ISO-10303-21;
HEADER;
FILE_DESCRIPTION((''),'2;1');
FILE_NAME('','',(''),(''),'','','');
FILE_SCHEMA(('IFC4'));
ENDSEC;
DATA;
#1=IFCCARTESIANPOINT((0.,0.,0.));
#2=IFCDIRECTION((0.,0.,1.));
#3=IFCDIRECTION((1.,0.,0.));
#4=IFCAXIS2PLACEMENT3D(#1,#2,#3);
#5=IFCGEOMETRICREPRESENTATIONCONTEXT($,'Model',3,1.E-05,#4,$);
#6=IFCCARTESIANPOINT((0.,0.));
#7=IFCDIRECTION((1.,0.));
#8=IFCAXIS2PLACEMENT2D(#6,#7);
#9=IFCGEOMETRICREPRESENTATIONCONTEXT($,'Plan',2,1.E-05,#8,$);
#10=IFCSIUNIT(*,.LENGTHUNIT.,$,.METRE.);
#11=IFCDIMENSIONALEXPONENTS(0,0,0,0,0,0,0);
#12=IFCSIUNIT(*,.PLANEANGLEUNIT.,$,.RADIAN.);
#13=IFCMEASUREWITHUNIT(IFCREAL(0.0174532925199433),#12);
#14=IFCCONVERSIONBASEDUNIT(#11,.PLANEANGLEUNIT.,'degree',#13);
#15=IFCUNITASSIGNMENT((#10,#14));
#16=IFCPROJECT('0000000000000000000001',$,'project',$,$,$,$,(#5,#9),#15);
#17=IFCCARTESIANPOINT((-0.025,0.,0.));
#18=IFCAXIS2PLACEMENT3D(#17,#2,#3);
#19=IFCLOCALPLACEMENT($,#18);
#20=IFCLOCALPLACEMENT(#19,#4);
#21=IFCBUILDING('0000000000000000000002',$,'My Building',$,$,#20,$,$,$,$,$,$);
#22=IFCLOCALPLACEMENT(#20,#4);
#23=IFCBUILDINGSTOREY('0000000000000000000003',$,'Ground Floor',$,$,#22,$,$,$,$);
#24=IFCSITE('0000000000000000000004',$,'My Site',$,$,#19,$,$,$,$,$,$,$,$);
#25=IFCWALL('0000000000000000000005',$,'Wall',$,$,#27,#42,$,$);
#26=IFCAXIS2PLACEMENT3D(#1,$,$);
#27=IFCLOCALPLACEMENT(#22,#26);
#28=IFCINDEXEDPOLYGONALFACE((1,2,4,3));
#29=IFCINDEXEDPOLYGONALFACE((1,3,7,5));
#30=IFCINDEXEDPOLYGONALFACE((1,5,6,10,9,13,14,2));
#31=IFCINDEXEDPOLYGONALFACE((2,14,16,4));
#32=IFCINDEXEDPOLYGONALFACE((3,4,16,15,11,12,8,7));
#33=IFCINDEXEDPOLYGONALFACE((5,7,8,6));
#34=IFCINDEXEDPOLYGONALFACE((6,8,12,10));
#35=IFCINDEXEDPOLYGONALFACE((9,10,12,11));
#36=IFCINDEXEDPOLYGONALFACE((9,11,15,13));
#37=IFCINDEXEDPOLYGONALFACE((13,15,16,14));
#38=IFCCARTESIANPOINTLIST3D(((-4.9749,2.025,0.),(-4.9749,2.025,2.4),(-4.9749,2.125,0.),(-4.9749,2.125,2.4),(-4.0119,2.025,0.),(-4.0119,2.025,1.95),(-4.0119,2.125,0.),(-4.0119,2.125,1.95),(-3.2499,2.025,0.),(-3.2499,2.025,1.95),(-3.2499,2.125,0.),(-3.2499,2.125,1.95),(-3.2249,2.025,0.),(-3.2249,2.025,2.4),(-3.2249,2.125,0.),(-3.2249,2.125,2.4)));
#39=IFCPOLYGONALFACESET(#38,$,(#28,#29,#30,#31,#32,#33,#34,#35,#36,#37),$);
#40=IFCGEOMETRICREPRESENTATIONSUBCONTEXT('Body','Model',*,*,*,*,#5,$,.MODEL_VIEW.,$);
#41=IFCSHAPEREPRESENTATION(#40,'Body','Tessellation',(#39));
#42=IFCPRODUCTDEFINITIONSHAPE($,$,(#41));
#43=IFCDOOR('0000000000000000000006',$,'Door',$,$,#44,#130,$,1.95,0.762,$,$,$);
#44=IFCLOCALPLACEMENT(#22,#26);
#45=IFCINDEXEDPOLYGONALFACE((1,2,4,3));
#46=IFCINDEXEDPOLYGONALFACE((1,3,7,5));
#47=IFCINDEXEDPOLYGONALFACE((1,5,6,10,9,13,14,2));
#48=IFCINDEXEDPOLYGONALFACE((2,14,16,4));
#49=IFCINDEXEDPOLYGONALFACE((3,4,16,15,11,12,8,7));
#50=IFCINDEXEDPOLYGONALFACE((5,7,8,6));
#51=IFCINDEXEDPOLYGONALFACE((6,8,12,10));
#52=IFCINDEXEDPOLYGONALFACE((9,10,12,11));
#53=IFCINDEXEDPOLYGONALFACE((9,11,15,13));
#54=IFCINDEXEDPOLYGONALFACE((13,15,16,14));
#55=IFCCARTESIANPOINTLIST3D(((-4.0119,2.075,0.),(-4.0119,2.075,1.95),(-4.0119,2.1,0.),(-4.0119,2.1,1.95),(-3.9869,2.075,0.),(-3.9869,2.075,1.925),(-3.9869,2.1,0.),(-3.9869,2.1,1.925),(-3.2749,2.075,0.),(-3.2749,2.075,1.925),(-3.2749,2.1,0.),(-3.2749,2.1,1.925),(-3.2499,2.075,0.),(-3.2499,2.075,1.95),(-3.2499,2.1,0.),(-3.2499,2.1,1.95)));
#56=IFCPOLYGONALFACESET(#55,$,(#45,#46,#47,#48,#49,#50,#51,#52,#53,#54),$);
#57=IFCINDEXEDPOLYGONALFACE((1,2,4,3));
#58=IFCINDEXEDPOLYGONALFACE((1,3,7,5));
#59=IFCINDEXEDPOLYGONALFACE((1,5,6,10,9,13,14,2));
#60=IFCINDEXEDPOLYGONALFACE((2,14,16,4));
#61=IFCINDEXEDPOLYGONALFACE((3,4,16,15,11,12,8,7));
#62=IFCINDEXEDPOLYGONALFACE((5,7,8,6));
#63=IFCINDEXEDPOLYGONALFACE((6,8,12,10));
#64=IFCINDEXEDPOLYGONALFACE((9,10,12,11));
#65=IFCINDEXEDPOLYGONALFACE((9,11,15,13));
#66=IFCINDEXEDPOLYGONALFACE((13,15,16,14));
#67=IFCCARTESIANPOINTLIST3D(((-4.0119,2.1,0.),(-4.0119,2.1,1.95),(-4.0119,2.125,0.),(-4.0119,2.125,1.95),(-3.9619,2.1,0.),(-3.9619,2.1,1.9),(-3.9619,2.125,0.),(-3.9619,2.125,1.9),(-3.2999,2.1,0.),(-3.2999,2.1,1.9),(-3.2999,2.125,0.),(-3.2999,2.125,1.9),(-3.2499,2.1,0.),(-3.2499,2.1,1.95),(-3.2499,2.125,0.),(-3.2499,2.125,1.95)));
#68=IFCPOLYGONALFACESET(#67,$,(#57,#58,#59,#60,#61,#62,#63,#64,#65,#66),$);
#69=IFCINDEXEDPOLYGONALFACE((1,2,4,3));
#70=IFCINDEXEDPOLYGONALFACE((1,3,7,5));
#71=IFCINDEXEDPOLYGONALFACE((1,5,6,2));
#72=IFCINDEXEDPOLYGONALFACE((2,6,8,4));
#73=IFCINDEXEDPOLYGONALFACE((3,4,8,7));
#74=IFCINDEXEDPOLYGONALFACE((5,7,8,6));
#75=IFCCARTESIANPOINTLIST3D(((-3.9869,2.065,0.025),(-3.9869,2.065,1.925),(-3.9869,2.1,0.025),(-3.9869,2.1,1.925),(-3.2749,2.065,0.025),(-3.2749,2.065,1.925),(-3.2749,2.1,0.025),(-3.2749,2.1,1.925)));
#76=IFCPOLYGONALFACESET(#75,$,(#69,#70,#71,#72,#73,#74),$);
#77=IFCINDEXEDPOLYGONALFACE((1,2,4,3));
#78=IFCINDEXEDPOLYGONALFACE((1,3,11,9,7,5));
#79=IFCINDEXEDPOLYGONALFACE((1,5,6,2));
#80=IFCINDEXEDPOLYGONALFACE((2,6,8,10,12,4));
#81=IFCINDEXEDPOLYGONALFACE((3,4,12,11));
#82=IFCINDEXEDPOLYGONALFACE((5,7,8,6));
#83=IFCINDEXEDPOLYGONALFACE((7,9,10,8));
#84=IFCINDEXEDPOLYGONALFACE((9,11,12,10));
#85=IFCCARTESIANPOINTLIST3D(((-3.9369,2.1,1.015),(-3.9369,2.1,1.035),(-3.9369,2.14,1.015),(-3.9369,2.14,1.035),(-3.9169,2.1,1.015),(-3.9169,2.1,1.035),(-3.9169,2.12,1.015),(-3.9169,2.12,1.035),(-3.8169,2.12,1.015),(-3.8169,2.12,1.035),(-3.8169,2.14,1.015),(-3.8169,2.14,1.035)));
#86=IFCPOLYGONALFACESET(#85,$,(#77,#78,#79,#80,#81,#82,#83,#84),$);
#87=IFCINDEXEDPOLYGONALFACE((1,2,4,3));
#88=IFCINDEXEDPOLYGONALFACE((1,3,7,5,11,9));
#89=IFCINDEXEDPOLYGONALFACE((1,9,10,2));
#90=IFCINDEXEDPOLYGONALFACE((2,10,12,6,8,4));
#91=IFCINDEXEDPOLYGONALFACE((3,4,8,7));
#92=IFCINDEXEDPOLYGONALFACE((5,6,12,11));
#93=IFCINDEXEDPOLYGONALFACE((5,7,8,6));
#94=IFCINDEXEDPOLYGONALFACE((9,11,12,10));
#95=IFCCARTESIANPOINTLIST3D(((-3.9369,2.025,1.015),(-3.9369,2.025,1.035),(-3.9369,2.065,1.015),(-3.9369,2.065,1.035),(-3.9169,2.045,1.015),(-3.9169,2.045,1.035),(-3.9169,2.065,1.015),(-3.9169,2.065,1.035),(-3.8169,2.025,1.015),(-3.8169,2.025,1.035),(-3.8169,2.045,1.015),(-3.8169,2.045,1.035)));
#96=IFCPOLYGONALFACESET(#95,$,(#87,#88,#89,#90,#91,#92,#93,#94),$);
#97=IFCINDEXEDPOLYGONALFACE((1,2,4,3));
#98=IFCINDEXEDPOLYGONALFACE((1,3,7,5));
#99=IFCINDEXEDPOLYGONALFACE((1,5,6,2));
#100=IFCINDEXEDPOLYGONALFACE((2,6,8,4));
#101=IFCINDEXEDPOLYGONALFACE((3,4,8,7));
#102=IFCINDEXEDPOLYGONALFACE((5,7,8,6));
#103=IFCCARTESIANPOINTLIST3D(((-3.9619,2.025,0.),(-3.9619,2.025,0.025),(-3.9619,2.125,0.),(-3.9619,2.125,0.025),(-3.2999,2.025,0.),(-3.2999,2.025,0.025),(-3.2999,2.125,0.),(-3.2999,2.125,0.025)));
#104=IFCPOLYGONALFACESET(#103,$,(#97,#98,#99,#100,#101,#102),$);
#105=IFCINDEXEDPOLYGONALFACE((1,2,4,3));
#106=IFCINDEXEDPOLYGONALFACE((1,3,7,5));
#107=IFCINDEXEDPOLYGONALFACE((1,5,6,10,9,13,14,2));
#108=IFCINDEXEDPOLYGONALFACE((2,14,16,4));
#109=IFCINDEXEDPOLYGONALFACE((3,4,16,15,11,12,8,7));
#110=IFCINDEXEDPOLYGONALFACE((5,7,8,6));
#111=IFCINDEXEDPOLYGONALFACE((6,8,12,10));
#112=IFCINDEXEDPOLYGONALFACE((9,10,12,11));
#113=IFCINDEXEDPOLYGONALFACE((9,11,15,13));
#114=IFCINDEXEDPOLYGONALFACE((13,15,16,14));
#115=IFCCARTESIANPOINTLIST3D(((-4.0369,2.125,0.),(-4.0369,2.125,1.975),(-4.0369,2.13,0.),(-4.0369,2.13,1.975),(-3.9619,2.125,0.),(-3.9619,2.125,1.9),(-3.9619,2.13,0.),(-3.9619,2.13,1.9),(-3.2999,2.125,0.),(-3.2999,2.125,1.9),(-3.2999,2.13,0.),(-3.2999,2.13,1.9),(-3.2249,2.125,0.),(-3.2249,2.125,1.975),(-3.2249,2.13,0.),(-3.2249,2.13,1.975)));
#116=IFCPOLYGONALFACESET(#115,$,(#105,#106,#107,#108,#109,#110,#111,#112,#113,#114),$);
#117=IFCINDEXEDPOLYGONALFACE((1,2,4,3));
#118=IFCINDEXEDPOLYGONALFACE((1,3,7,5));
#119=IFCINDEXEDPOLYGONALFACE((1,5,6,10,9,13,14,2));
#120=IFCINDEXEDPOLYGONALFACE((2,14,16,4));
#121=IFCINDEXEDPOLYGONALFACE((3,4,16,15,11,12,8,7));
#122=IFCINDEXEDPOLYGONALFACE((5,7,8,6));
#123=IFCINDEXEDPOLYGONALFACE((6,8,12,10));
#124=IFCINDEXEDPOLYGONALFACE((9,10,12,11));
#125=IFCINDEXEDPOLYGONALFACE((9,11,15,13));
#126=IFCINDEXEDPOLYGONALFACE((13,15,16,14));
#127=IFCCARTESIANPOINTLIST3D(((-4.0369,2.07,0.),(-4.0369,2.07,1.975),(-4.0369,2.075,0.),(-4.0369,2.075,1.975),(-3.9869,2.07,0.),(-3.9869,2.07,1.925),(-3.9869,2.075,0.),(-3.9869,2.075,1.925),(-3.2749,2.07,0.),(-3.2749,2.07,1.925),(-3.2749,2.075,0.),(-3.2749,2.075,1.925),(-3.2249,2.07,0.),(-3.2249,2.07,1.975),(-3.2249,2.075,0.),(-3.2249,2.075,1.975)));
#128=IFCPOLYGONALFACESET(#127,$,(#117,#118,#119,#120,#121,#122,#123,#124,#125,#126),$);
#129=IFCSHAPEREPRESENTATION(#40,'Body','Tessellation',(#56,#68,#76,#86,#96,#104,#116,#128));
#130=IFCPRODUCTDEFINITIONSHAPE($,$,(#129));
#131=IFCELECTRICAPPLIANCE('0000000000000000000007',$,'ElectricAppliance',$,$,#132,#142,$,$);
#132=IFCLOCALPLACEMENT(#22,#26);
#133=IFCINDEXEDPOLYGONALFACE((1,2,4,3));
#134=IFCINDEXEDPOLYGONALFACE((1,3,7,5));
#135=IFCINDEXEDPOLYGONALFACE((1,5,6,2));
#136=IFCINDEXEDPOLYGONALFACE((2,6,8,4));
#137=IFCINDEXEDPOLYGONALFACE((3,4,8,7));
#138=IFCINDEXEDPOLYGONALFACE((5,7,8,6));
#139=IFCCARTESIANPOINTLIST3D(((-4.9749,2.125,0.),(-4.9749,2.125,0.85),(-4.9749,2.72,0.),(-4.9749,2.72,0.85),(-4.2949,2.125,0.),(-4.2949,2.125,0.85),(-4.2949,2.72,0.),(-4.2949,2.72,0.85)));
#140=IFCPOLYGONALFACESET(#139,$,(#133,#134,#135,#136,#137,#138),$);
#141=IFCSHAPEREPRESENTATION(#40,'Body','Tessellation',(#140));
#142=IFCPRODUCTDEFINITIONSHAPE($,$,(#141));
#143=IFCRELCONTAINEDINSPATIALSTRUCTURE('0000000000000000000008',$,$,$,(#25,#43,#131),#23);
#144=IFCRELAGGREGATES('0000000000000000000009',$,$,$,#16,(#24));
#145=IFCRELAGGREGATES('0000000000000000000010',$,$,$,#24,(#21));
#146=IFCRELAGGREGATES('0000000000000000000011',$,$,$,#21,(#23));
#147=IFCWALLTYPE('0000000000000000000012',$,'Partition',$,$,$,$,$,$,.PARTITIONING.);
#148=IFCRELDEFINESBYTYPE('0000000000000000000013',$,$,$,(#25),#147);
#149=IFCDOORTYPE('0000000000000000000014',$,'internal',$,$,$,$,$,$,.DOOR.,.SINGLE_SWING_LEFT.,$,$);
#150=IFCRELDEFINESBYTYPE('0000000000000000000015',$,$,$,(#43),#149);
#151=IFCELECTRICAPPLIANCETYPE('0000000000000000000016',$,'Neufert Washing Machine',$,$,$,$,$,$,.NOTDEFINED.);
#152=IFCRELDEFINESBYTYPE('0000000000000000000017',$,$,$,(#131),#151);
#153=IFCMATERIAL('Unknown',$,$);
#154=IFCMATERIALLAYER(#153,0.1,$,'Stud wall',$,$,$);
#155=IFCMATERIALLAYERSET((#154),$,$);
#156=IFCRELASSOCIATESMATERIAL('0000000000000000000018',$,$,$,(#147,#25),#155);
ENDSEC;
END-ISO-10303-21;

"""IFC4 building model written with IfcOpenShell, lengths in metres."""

from ifc_helpers import new_model, entity, si_unit, converted_unit, frame, origin_with_axes, origin_2d_with_axis, place, context, subcontext, project, spatial, line, indexed_curve, outline, extrude, shape, source, transform, mapped, material, layer, layer_set, layer_usage, type_object, type_shapes, element, fill, save


model = new_model("IFC4")

# Units and contexts
model_context = context("Model", 3, precision=1e-05, world=origin_with_axes())
plan_context = context("Plan", 2, precision=1e-05, world=origin_2d_with_axis())
body_context_1 = subcontext(model_context, "Body", "Model", "MODEL_VIEW")
body_context_2 = subcontext(plan_context, "Body", "Plan", "PLAN_VIEW")
ifc_project = project(units=[si_unit("LENGTHUNIT", "METRE"), converted_unit("PLANEANGLEUNIT", "degree", entity("IfcReal", 0.0174532925199433), si_unit("PLANEANGLEUNIT", "RADIAN"), dimensions=[0, 0, 0, 0, 0, 0, 0])], contexts=[model_context, plan_context])

# Site, building, storey
site_placement = place(None, frame((-0.025, 0.0, 0.0), z_axis=(0.0, 0.0, 1.0), x_axis=(1.0, 0.0, 0.0)))
site = spatial("IfcSite", under=ifc_project, at=site_placement, Name="My Site")
building_placement = place(site_placement, origin_with_axes())
building = spatial("IfcBuilding", under=site, at=building_placement, Name="My Building")
storey_placement = place(building_placement, frame((0.0, 0.0, 0.0), z_axis=(0.0, 0.0, 1.0), x_axis=(1.0, 0.0, 0.0)))
storey = spatial("IfcBuildingStorey", under=building, at=storey_placement, Name="Ground Floor")

# Shared definitions
ifc_material = material(Name="Unknown")
shared_shape_1 = source(origin_with_axes(), body_context_1, "Body", "SweptSolid", [
    extrude(outline(indexed_curve([(0.0, 0.0), (0.762, 0.0), (0.762, 1.95), (0.0, 1.95)], segments=[line(1, 2, 3, 4, 1)])), frame((0.0, -0.1, 0.0), z_axis=(0.0, -1.0, 0.0), x_axis=(1.0, 0.0, 0.0)), (0.0, 0.0, -1.0), 0.3),
])
door_type = type_object("IfcDoorType", Name="internal", OperationType="SINGLE_SWING_LEFT", PredefinedType="DOOR")
shared_shape_2 = source(origin_with_axes(), body_context_1, "Body", "SweptSolid", [
    extrude(outline(indexed_curve([(0.0, 0.0), (0.0, 1.95), (0.762, 1.95), (0.762, 0.0), (0.737, 0.0), (0.737, 1.925), (0.025, 1.925), (0.025, 0.0)], segments=[line(1, 2, 3, 4, 5, 6, 7, 8, 1)])), frame((0.0, 0.025, 0.0), z_axis=(0.0, -1.0, 0.0), x_axis=(1.0, 0.0, 0.0)), (0.0, 0.0, -1.0), 0.025),
    extrude(outline(indexed_curve([(0.0, 0.0), (0.0, 1.95), (0.762, 1.95), (0.762, 0.0), (0.712, 0.0), (0.712, 1.9), (0.05, 1.9), (0.05, 0.0)], segments=[line(1, 2, 3, 4, 5, 6, 7, 8, 1)])), frame((0.0, 0.0, 0.0), z_axis=(0.0, -1.0, 0.0), x_axis=(1.0, 0.0, 0.0)), (0.0, 0.0, -1.0), 0.025),
    extrude(outline(indexed_curve([(0.0, 0.0), (0.712, 0.0), (0.712, 0.035), (0.0, 0.035)], segments=[line(1, 2, 3, 4, 1)])), frame((0.025, 0.025, 0.025), z_axis=(0.0, 0.0, 1.0), x_axis=(1.0, 0.0, 0.0)), (0.0, 0.0, 1.0), 1.9),
    extrude(outline(indexed_curve([(0.0, 0.0), (0.0, -0.04), (-0.12, -0.04), (-0.12, -0.02), (-0.02, -0.02), (-0.02, 0.0)], segments=[line(1, 2, 3, 4, 5, 6, 1)])), frame((0.687, 0.025, 1.015), z_axis=(0.0, 0.0, 1.0), x_axis=(1.0, 0.0, 0.0)), (0.0, 0.0, 1.0), 0.02),
    extrude(outline(indexed_curve([(0.0, 0.0), (0.0, 0.04), (-0.12, 0.04), (-0.12, 0.02), (-0.02, 0.02), (-0.02, 0.0)], segments=[line(1, 2, 3, 4, 5, 6, 1)])), frame((0.687, 0.06, 1.015), z_axis=(0.0, 0.0, 1.0), x_axis=(1.0, 0.0, 0.0)), (0.0, 0.0, 1.0), 0.02),
    extrude(outline(indexed_curve([(0.0, 0.0), (0.662, 0.0), (0.662, 0.1), (0.0, 0.1)], segments=[line(1, 2, 3, 4, 1)])), frame((0.05, 0.0, 0.0), z_axis=(0.0, 0.0, 1.0), x_axis=(1.0, 0.0, 0.0)), (0.0, 0.0, 1.0), 0.025),
    extrude(outline(indexed_curve([(0.0, 0.0), (0.0, 1.975), (0.812, 1.975), (0.812, 0.0), (0.737, 0.0), (0.737, 1.9), (0.075, 1.9), (0.075, 0.0)], segments=[line(1, 2, 3, 4, 5, 6, 7, 8, 1)])), frame((-0.025, -0.005, 0.0), z_axis=(0.0, -1.0, 0.0), x_axis=(1.0, 0.0, 0.0)), (0.0, 0.0, -1.0), 0.005),
    extrude(outline(indexed_curve([(0.0, 0.0), (0.0, 1.975), (0.812, 1.975), (0.812, 0.0), (0.762, 0.0), (0.762, 1.925), (0.05, 1.925), (0.05, 0.0)], segments=[line(1, 2, 3, 4, 5, 6, 7, 8, 1)])), frame((-0.025, 0.05, 0.0), z_axis=(0.0, -1.0, 0.0), x_axis=(1.0, 0.0, 0.0)), (0.0, 0.0, -1.0), 0.005),
])
shared_shape_3 = source(origin_with_axes(), body_context_2, "Body", "Curve2D", [
    entity("IfcIndexedPolyCurve", entity("IfcCartesianPointList2D", [[0.0, 0.0], [0.0, 0.05], [0.025, 0.05], [0.025, 0.025], [0.05, 0.025], [0.05, 0.0]]), [entity("IfcLineIndex", [1, 2, 3, 4, 5, 6, 1])]),
    entity("IfcIndexedPolyCurve", entity("IfcCartesianPointList2D", [[0.762, 0.0], [0.762, 0.05], [0.737, 0.05], [0.737, 0.025], [0.712, 0.025], [0.712, 0.0]]), [entity("IfcLineIndex", [1, 2, 3, 4, 5, 6, 1])]),
    entity("IfcTrimmedCurve", entity("IfcEllipse", entity("IfcAxis2Placement2D", entity("IfcCartesianPoint", [0.06, 0.05]), entity("IfcDirection", [1.0, 0.0])), 0.677, 0.712), [entity("IfcCartesianPoint", [0.737, 0.05])], [entity("IfcCartesianPoint", [0.06, 0.762])], True, "CARTESIAN"),
    entity("IfcIndexedPolyCurve", entity("IfcCartesianPointList2D", [[0.025, 0.05], [0.06, 0.05], [0.06, 0.762], [0.025, 0.762]]), [entity("IfcLineIndex", [1, 2, 3, 4, 1])]),
])
type_shapes(door_type, [shared_shape_2, shared_shape_3])

# Wall, opening, door
ifc_layer_1 = layer(ifc_material, 0.1, Name="Stud wall")
ifc_layer_set_1 = layer_set([ifc_layer_1])
wall_type_1 = type_object("IfcWallType", Name="Partition", PredefinedType="PARTITIONING", material=ifc_layer_set_1)
ifc_layer_usage_1 = layer_usage(ifc_layer_set_1, "AXIS2", "POSITIVE", 0.0)
wall_1_placement = place(storey_placement, frame((-3.2249, 2.125, 0.0), z_axis=(0.0, 0.0, 1.0), x_axis=(-1.0, 0.0, 0.0)))
wall_1 = element("IfcWall", 1, at=wall_1_placement, inside=storey, type_object=wall_type_1, material=ifc_layer_usage_1, Name="Wall", context=body_context_1, shape_type="SweptSolid", body=[
    extrude(outline(indexed_curve([(0.0, 0.0), (0.0, 0.1), (1.75, 0.1), (1.75, 0.0), (0.0, 0.0)], self_intersect=False)), origin_with_axes(), (0.0, 0.0, 1.0), 2.4),
])
opening_1_placement = place(wall_1_placement, frame((0.025, 0.0, 0.0), z_axis=(0.0, 0.0, 1.0), x_axis=(1.0, 0.0, 0.0)))
opening_1 = element("IfcOpeningElement", 2, at=opening_1_placement, cuts=wall_1, PredefinedType="OPENING", context=body_context_1, shape_type="MappedRepresentation", body=[
    mapped(shared_shape_1, transform((0.0, 0.0, 0.0), x_axis=(1.0, 0.0, 0.0), y_axis=(0.0, 1.0, 0.0), z_axis=(0.0, 0.0, 1.0), scale=1.0)),
])
door_1_placement = place(opening_1_placement, frame((0.0, 0.0, 0.0), z_axis=(0.0, 0.0, 1.0), x_axis=(1.0, 0.0, 0.0)))
door_1 = element("IfcDoor", 3, at=door_1_placement, inside=storey, type_object=door_type, Name="Door", OverallHeight=1.95, OverallWidth=0.762, shapes=[
    shape(body_context_1, "Body", "MappedRepresentation", [mapped(shared_shape_2, transform((0.0, 0.0, 0.0), x_axis=(1.0, 0.0, 0.0), y_axis=(0.0, 1.0, 0.0), z_axis=(0.0, 0.0, 1.0), scale=1.0))]),
    shape(body_context_2, "Body", "MappedRepresentation", [mapped(shared_shape_3, transform((0.0, 0.0, 0.0), x_axis=(1.0, 0.0, 0.0), y_axis=(0.0, 1.0, 0.0), z_axis=(0.0, 0.0, 1.0), scale=1.0))]),
])
fill(opening_1, door_1)

# Electric appliance
electric_appliance_type_1 = type_object("IfcElectricApplianceType", Name="Neufert Washing Machine", PredefinedType="NOTDEFINED")
shared_shape_4 = source(origin_with_axes(), body_context_1, "Body", "SweptSolid", [
    extrude(outline(indexed_curve([(0.0, 0.0), (0.595, 0.0), (0.595, 0.68), (0.0, 0.68)], segments=[line(1, 2, 3, 4, 1)])), origin_with_axes(), (0.0, 0.0, 1.0), 0.85),
])
shared_shape_5 = source(origin_with_axes(), body_context_2, "Body", "Curve2D", [
    entity("IfcIndexedPolyCurve", entity("IfcCartesianPointList2D", [[0.0, 0.0], [0.595, 0.0], [0.595, 0.68], [0.0, 0.68]]), [entity("IfcLineIndex", [1, 2, 3, 4, 1])]),
    entity("IfcCircle", entity("IfcAxis2Placement2D", entity("IfcCartesianPoint", [0.2975, 0.34])), 0.1785),
    entity("IfcCircle", entity("IfcAxis2Placement2D", entity("IfcCartesianPoint", [0.2975, 0.34])), 0.0595),
])
type_shapes(electric_appliance_type_1, [shared_shape_4, shared_shape_5])
electric_appliance_1_placement = place(storey_placement, frame((-4.2949, 2.125, 0.0), z_axis=(0.0, 0.0, 1.0), x_axis=(0.0, 1.0, 0.0)))
element("IfcElectricAppliance", 4, at=electric_appliance_1_placement, inside=storey, type_object=electric_appliance_type_1, Name="ElectricAppliance", shapes=[
    shape(body_context_1, "Body", "MappedRepresentation", [mapped(shared_shape_4, transform((0.0, 0.0, 0.0), x_axis=(1.0, 0.0, 0.0), y_axis=(0.0, 1.0, 0.0), z_axis=(0.0, 0.0, 1.0), scale=1.0))]),
    shape(body_context_2, "Body", "MappedRepresentation", [mapped(shared_shape_5, transform((0.0, 0.0, 0.0), x_axis=(1.0, 0.0, 0.0), y_axis=(0.0, 1.0, 0.0), z_axis=(0.0, 0.0, 1.0), scale=1.0))]),
])

save(model, "model.ifc")
